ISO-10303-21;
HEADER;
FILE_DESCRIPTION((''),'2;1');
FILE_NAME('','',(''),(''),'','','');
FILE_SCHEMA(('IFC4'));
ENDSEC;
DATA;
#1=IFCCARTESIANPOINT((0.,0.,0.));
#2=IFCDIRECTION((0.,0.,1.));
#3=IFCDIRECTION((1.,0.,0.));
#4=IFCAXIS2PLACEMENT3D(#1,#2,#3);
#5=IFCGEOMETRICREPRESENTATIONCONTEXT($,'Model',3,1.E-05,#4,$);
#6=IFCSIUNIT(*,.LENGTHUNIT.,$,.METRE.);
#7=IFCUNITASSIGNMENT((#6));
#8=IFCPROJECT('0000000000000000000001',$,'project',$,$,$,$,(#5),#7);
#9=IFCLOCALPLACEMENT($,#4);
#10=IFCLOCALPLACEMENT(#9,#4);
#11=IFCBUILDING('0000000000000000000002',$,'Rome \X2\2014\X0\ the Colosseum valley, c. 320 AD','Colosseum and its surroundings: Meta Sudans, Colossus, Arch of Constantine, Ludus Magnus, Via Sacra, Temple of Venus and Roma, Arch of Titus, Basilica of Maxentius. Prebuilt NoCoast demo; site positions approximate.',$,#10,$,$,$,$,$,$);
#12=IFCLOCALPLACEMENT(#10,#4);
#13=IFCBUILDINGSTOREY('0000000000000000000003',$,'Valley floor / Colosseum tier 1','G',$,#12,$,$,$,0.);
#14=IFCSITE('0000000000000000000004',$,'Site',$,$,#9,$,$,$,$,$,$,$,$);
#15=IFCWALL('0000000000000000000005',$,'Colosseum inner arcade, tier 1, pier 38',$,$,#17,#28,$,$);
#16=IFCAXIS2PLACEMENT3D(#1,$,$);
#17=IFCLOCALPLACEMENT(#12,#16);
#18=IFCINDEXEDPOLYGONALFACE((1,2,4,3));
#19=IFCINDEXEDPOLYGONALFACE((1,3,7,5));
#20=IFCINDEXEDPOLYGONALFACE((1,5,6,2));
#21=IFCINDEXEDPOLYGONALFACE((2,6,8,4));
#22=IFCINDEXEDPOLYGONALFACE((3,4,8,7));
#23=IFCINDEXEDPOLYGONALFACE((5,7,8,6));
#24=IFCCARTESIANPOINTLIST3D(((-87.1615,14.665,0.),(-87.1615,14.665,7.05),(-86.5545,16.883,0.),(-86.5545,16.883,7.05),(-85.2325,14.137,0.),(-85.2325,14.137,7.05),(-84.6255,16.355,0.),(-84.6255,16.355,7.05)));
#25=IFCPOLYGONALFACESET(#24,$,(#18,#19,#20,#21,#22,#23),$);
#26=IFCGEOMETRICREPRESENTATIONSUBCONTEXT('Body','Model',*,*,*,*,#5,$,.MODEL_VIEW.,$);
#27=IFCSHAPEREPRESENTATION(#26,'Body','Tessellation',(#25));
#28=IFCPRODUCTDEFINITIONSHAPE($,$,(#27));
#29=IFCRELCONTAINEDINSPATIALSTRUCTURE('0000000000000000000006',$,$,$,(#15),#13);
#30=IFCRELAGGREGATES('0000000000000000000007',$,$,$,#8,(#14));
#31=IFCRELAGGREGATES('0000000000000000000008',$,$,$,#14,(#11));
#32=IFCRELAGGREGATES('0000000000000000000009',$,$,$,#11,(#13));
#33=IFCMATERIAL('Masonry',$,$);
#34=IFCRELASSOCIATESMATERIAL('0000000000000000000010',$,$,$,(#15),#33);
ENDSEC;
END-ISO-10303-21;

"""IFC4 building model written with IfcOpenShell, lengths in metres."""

from ifc_helpers import new_model, si_unit, frame, origin_with_axes, place, context, subcontext, project, spatial, indexed_curve, outline, extrude, material, element, save


model = new_model("IFC4")

# Units and contexts
model_context = context("Model", 3, precision=1e-05, world=origin_with_axes())
body_context = subcontext(model_context, "Body", "Model", "MODEL_VIEW")
ifc_project = project(units=[si_unit("LENGTHUNIT", "METRE")], contexts=[model_context])

# Site, building, storey
site_placement = place(None, origin_with_axes())
site = spatial("IfcSite", under=ifc_project, at=site_placement, Name="Site")
building_placement = place(site_placement, origin_with_axes())
building = spatial("IfcBuilding", under=site, at=building_placement, Name="Rome — the Colosseum valley, c. 320 AD", Description="Colosseum and its surroundings: Meta Sudans, Colossus, Arch of Constantine, Ludus Magnus, Via Sacra, Temple of Venus and Roma, Arch of Titus, Basilica of Maxentius. Prebuilt NoCoast demo; site positions approximate.")
storey_placement = place(building_placement, origin_with_axes())
storey = spatial("IfcBuildingStorey", under=building, at=storey_placement, Name="Valley floor / Colosseum tier 1", Description="G", Elevation=0.0)

# Wall
ifc_material = material(Name="Masonry")
wall_1_placement = place(storey_placement, frame((-85.59, 16.619, 0.0), z_axis=(0.0, 0.0, 1.0), x_axis=(-0.263964, -0.964533, 0.0)))
element("IfcWall", 1, at=wall_1_placement, inside=storey, material=ifc_material, Name="Colosseum inner arcade, tier 1, pier 38", context=body_context, shape_type="SweptSolid", body=[
    extrude(outline(indexed_curve([(0.0, 0.0), (0.0, 2.0), (2.2996, 2.0), (2.2996, 0.0), (0.0, 0.0)], self_intersect=False)), frame((0.0, -1.0, 0.0), z_axis=(0.0, 0.0, 1.0), x_axis=(1.0, 0.0, 0.0)), (0.0, 0.0, 1.0), 7.05),
])

save(model, "model.ifc")
